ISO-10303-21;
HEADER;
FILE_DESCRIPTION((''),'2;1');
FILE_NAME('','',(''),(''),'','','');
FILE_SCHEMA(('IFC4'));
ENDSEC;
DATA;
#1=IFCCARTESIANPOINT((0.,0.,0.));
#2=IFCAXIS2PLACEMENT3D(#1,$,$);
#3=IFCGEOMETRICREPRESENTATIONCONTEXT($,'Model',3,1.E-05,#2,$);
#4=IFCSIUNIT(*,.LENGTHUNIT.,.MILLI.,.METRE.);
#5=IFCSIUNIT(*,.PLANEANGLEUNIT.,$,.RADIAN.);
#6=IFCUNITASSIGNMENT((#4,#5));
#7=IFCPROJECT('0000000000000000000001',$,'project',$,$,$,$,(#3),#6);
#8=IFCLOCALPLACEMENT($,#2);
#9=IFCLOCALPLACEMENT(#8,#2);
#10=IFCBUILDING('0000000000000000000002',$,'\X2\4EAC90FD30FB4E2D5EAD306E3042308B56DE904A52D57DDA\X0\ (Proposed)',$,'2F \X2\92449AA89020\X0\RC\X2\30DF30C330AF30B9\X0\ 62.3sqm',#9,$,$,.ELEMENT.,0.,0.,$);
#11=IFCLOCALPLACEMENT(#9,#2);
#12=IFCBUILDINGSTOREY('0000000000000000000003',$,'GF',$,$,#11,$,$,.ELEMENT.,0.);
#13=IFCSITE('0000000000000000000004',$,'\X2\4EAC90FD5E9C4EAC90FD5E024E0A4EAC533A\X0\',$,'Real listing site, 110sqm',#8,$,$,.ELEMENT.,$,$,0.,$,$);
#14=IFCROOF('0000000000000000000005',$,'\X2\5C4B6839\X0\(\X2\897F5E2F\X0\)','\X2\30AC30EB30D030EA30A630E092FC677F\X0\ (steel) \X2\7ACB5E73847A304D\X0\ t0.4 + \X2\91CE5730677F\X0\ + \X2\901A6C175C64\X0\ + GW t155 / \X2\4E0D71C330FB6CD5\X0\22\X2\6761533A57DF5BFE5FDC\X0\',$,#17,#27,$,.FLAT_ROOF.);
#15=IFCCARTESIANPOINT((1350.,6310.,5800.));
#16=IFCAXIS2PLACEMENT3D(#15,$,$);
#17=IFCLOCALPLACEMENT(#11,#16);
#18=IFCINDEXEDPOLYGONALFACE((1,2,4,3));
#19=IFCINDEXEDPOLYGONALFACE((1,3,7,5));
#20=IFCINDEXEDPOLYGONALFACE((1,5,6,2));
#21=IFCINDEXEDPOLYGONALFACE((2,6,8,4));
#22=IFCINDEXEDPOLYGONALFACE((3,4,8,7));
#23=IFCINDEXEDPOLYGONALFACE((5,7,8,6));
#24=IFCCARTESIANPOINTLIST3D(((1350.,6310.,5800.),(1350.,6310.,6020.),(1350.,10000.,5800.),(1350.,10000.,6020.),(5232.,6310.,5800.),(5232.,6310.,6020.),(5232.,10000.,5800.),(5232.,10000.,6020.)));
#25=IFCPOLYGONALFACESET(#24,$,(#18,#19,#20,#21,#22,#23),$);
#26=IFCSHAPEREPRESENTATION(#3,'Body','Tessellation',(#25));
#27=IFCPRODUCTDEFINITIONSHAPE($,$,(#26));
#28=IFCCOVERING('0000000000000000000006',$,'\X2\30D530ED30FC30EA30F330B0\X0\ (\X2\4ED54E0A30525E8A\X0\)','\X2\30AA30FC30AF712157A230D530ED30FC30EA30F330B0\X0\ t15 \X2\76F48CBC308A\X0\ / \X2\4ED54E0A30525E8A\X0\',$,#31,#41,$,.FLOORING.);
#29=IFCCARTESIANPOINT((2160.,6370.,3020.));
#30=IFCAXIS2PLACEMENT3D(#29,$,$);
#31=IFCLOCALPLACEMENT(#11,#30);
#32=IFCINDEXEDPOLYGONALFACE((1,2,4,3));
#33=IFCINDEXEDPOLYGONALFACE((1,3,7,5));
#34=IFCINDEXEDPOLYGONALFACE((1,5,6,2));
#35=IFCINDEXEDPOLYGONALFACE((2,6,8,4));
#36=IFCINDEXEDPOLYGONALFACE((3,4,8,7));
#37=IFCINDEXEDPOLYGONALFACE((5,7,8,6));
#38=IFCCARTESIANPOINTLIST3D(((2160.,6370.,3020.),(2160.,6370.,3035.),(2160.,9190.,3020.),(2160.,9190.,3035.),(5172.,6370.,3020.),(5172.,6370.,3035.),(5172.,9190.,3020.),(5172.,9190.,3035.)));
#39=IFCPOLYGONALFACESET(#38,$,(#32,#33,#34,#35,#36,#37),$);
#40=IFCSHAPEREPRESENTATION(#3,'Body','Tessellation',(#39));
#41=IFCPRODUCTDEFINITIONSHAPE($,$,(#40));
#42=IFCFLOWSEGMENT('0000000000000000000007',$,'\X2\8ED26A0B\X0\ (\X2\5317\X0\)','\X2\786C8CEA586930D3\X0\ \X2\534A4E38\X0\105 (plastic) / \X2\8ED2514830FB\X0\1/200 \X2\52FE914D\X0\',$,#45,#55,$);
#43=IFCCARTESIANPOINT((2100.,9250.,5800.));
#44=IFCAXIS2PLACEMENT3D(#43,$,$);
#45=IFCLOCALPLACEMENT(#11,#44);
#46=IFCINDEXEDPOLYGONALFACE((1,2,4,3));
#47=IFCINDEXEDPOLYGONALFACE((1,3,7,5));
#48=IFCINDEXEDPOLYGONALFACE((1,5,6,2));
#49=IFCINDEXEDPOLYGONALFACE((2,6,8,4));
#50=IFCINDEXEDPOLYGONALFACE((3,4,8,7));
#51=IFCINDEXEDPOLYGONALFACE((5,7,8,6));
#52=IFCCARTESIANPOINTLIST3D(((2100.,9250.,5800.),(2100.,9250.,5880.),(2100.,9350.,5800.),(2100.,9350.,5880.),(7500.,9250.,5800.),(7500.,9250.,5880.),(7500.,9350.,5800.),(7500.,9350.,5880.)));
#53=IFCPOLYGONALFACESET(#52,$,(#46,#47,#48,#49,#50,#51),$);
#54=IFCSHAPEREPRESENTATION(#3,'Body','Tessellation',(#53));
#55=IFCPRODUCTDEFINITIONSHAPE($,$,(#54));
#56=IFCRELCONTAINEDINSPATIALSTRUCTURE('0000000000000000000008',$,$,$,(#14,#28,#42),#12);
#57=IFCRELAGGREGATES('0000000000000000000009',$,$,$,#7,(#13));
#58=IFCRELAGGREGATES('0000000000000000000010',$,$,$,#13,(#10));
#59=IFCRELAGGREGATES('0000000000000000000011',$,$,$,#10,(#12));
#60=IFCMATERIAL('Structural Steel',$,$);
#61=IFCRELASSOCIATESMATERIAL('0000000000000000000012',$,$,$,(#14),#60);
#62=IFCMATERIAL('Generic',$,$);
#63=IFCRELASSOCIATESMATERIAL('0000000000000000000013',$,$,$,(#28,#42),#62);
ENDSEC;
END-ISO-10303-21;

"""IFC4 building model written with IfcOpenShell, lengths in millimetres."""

from ifc_helpers import new_model, si_unit, frame, frame_2d, origin, place, context, project, spatial, rectangle, extrude, material, element, save


model = new_model("IFC4")

# Units and contexts
model_context = context("Model", 3, precision=1e-05, world=origin())
ifc_project = project(units=[si_unit("LENGTHUNIT", "METRE", prefix="MILLI"), si_unit("PLANEANGLEUNIT", "RADIAN")], contexts=[model_context])

# Site, building, storey
site_placement = place(None, origin())
site = spatial("IfcSite", under=ifc_project, at=site_placement, Name="京都府京都市上京区", ObjectType="Real listing site, 110sqm", CompositionType="ELEMENT", RefElevation=0.0)
building_placement = place(site_placement, origin())
building = spatial("IfcBuilding", under=site, at=building_placement, Name="京都・中庭のある回遊動線 (Proposed)", ObjectType="2F 鉄骨造RCミックス 62.3sqm", CompositionType="ELEMENT", ElevationOfRefHeight=0.0, ElevationOfTerrain=0.0)
storey_placement = place(building_placement, origin())
storey = spatial("IfcBuildingStorey", under=building, at=storey_placement, Name="GF", CompositionType="ELEMENT", Elevation=0.0)

# Roof
ifc_material_1 = material(Name="Structural Steel")
for number, where, name in (
    (1, (1350.0, 6310.0, 5800.0), "屋根(西帯)"),
):
    element("IfcRoof", number, at=place(storey_placement, frame(where)), inside=storey, material=ifc_material_1, Name=name, Description="ガルバリウム鋼板 (steel) 立平葺き t0.4 + 野地板 + 通気層 + GW t155 / 不燃・法22条区域対応", PredefinedType="FLAT_ROOF", context=model_context, shape_type="SweptSolid", body=[
        extrude(rectangle(XDim=3882.0, YDim=3690.0, at=frame_2d((1941.0, 1845.0))), frame((1350.0, 6310.0, 5800.0)), (0.0, 0.0, 1.0), 220.0),
    ])

# Covering
ifc_material_2 = material(Name="Generic")
covering_placement = place(storey_placement, frame((2160.0, 6370.0, 3020.0)))
element("IfcCovering", 2, at=covering_placement, inside=storey, material=ifc_material_2, Name="フローリング (仕上げ床)", Description="オーク無垢フローリング t15 直貼り / 仕上げ床", PredefinedType="FLOORING", context=model_context, shape_type="SweptSolid", body=[
    extrude(rectangle(XDim=3012.0, YDim=2820.0, at=frame_2d((1506.0, 1410.0))), frame((2160.0, 6370.0, 3020.0)), (0.0, 0.0, 1.0), 15.0),
])

# Flow segment
flow_segment_placement = place(storey_placement, frame((2100.0, 9250.0, 5800.0)))
element("IfcFlowSegment", 3, at=flow_segment_placement, inside=storey, material=ifc_material_2, Name="軒樋 (北)", Description="硬質塩ビ 半丸105 (plastic) / 軒先・1/200 勾配", context=model_context, shape_type="SweptSolid", body=[
    extrude(rectangle(XDim=5400.0, YDim=100.0, at=frame_2d((2700.0, 50.0))), frame((2100.0, 9250.0, 5800.0)), (0.0, 0.0, 1.0), 80.0),
])

save(model, "model.ifc")
